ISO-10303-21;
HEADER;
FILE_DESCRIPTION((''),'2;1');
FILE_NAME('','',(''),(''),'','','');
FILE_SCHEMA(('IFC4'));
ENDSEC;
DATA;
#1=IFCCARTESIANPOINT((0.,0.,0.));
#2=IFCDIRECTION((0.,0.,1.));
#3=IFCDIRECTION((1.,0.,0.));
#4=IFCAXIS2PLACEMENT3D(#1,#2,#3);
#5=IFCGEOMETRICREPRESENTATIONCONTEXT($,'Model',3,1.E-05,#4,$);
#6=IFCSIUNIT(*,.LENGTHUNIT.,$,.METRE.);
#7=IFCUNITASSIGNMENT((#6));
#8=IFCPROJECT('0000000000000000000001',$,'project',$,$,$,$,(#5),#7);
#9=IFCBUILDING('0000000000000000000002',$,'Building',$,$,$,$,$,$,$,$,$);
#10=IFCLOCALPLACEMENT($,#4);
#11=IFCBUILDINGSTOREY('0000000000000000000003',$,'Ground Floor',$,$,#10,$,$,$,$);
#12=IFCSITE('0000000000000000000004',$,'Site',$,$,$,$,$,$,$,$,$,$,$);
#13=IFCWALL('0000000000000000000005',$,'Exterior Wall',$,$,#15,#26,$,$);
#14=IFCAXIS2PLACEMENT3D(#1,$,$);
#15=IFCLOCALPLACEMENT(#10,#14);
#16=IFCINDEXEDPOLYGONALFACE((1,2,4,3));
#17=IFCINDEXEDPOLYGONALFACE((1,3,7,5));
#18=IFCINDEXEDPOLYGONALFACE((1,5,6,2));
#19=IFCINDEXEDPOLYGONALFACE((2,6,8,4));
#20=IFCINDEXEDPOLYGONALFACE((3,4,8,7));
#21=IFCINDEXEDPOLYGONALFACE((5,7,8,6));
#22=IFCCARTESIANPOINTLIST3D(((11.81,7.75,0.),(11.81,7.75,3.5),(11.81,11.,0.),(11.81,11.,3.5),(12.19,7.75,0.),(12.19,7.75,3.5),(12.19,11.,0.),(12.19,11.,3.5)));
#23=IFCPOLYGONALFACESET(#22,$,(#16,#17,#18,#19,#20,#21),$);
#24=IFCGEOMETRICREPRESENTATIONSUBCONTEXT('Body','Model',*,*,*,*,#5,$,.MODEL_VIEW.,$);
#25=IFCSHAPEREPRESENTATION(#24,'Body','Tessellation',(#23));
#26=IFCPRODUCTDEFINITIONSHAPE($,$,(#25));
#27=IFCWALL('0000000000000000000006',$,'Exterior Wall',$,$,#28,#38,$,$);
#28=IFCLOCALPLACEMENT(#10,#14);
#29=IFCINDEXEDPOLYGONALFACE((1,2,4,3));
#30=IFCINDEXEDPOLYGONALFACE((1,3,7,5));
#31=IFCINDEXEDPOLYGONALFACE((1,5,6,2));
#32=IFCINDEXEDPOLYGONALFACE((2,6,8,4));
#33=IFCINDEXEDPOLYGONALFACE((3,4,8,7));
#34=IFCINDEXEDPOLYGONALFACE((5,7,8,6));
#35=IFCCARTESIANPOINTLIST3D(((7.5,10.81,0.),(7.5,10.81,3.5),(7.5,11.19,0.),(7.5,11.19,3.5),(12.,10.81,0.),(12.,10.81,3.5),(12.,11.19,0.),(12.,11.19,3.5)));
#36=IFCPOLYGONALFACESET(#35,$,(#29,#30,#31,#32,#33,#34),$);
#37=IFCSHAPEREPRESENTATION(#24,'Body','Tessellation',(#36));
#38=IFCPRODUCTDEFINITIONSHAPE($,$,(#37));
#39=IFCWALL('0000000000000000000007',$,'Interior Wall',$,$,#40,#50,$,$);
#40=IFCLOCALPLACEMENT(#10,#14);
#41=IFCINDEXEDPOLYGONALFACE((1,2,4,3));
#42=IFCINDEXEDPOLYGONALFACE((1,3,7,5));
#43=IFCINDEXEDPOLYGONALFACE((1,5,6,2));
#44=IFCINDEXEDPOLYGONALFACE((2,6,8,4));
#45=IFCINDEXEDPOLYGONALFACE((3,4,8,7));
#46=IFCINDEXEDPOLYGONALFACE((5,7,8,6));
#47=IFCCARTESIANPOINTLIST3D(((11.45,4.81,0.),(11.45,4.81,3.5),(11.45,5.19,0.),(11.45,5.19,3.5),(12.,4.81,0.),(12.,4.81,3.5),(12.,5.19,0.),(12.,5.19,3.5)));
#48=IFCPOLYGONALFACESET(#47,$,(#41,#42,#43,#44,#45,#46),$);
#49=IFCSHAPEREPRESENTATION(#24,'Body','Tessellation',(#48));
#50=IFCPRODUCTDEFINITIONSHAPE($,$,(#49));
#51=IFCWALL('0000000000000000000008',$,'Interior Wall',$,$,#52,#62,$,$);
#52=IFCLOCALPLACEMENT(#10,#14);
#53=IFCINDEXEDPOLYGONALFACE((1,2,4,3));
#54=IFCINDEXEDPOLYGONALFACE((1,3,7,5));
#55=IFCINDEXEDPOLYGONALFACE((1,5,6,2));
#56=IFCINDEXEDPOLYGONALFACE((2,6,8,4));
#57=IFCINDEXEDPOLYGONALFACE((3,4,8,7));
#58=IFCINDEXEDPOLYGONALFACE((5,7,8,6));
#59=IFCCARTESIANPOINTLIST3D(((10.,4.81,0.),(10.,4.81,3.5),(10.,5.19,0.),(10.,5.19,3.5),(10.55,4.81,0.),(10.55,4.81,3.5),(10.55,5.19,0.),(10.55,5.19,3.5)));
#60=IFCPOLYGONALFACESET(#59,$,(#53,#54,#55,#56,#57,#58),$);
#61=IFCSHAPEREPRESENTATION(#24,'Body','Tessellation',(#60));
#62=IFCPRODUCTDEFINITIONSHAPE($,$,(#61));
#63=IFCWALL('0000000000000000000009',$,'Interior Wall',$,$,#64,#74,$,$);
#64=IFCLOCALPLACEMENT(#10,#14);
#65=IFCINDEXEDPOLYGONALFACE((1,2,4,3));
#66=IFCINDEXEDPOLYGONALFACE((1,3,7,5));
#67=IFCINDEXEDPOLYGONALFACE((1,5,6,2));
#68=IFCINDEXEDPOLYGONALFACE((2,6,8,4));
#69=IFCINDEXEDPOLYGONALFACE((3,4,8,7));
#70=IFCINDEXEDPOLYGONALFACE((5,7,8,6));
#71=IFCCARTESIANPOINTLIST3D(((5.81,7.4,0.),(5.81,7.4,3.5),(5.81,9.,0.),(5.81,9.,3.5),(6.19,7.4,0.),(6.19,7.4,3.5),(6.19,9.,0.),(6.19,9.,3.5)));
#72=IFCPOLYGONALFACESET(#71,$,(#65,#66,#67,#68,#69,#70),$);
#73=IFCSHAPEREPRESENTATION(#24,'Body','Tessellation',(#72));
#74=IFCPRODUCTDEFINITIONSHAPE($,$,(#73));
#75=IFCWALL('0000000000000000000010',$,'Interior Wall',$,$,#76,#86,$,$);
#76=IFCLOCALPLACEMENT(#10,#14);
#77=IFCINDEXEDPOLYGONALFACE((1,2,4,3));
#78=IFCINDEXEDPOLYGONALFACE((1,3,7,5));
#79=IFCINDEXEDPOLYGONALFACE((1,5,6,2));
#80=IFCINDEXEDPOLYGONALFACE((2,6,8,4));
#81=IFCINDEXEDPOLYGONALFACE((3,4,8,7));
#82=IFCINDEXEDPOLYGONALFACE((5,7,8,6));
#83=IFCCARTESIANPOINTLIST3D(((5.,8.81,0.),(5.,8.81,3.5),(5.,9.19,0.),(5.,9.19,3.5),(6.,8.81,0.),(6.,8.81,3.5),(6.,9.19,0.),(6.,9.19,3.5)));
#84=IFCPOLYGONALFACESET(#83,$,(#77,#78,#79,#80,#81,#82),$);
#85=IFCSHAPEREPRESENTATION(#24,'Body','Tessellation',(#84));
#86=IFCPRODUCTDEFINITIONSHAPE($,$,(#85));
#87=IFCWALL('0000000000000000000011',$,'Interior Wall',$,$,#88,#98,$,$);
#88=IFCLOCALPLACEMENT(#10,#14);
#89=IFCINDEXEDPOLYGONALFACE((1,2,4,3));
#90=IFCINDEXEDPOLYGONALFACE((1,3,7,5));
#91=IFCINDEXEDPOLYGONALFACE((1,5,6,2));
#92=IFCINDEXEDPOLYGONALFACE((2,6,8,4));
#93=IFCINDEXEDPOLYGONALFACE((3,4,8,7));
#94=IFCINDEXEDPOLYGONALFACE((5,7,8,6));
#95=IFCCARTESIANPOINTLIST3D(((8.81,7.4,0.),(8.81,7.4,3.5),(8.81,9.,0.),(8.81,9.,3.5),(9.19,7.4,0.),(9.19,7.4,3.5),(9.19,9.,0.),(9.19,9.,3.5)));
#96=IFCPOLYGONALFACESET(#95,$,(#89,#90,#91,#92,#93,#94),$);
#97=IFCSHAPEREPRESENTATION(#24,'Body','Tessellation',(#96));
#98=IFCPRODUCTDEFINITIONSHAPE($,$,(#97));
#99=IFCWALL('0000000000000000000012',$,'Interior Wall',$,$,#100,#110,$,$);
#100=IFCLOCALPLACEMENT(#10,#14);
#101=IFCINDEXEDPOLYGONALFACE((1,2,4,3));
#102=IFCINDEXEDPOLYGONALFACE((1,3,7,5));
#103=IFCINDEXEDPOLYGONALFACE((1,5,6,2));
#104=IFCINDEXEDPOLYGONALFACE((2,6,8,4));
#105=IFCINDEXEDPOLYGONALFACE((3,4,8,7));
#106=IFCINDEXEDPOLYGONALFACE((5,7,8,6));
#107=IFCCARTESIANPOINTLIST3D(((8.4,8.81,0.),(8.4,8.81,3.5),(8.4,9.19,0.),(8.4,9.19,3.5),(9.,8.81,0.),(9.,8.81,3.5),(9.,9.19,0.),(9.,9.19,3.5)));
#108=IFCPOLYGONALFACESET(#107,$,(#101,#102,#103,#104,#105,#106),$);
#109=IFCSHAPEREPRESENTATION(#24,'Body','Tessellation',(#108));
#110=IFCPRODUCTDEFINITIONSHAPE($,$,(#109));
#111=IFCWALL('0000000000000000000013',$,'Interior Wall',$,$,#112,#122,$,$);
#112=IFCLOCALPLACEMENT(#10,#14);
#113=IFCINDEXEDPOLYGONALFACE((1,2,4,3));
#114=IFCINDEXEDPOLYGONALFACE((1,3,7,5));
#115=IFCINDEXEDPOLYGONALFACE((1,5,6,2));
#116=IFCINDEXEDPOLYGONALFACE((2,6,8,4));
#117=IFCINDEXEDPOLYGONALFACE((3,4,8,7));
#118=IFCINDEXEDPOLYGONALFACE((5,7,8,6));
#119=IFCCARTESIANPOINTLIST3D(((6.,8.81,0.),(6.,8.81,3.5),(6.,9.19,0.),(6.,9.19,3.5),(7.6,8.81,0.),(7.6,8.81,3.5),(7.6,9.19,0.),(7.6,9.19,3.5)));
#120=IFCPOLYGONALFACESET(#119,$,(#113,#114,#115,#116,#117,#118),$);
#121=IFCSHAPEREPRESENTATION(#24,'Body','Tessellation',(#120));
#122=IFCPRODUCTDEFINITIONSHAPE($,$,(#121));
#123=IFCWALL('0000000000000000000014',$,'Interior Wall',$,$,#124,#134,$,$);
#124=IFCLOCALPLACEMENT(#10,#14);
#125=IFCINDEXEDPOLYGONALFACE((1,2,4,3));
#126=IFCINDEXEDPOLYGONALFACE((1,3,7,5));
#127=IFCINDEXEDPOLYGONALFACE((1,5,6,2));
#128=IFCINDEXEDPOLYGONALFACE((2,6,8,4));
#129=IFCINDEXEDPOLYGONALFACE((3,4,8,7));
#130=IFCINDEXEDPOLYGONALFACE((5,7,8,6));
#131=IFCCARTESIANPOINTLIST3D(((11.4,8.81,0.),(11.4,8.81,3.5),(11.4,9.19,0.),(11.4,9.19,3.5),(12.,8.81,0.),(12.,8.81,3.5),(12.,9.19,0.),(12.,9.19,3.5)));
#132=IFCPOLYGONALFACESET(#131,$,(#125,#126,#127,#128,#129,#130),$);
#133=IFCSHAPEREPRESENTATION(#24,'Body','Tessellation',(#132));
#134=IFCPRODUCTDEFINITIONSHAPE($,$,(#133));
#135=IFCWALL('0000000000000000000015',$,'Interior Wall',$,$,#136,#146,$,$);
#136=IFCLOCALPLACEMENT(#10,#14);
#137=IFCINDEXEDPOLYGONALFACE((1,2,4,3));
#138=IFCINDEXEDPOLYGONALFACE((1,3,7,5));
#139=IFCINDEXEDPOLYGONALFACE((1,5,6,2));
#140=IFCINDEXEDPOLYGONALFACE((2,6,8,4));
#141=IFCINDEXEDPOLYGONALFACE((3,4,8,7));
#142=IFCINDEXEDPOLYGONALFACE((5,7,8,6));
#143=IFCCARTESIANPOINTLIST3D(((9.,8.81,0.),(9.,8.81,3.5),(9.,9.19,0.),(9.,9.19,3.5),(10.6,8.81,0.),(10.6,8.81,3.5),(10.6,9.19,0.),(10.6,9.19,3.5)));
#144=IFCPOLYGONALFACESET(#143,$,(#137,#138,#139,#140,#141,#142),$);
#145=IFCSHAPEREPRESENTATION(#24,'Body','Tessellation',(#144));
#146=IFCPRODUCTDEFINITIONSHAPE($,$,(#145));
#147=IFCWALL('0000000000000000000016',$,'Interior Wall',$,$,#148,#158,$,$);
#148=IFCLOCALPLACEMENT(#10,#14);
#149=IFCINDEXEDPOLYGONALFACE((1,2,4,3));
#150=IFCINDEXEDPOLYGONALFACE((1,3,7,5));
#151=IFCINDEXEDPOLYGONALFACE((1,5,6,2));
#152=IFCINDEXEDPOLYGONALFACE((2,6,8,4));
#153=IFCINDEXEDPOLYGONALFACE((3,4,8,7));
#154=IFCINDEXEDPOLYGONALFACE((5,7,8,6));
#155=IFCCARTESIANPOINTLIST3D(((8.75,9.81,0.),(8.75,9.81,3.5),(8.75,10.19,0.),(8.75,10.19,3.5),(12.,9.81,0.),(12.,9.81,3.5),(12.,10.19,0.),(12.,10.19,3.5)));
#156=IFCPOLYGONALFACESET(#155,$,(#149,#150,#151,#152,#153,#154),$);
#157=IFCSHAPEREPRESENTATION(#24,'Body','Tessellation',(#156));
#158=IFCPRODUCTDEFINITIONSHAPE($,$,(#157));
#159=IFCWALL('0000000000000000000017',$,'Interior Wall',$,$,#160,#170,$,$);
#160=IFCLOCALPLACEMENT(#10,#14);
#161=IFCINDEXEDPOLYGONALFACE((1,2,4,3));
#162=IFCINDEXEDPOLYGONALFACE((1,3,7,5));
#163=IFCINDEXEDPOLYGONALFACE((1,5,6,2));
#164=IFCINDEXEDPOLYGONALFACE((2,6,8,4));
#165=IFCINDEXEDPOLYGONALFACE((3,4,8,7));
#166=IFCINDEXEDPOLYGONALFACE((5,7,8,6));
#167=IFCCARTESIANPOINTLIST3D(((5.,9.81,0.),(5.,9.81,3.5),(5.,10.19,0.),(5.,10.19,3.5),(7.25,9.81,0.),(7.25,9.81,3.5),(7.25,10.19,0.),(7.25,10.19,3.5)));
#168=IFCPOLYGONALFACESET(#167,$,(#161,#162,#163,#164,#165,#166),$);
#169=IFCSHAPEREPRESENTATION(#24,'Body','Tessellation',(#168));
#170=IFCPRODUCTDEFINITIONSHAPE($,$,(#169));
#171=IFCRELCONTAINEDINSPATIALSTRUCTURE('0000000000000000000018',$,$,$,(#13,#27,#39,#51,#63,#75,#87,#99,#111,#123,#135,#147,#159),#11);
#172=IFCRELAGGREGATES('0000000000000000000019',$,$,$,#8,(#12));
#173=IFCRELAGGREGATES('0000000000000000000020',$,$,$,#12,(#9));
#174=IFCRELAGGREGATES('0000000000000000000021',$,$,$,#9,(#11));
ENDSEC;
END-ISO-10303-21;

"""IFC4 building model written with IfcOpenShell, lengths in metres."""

from ifc_helpers import new_model, si_unit, frame, origin_with_axes, place, context, subcontext, project, spatial, indexed_curve, outline, extrude, element, save


model = new_model("IFC4")

# Units and contexts
model_context = context("Model", 3, precision=1e-05, world=origin_with_axes())
body_context = subcontext(model_context, "Body", "Model", "MODEL_VIEW")
ifc_project = project(units=[si_unit("LENGTHUNIT", "METRE")], contexts=[model_context])

# Site, building, storey
site = spatial("IfcSite", under=ifc_project, Name="Site")
building = spatial("IfcBuilding", under=site, Name="Building")
storey_placement = place(None, origin_with_axes())
storey = spatial("IfcBuildingStorey", under=building, at=storey_placement, Name="Ground Floor")

# Walls
wall_1_placement = place(storey_placement, frame((12.0, 7.75, 0.0), z_axis=(0.0, 0.0, 1.0), x_axis=(0.0, 1.0, 0.0)))
element("IfcWall", 1, at=wall_1_placement, inside=storey, Name="Exterior Wall", context=body_context, shape_type="SweptSolid", body=[
    extrude(outline(indexed_curve([(0.0, 0.0), (0.0, 0.38), (3.25, 0.38), (3.25, 0.0), (0.0, 0.0)], self_intersect=False)), frame((0.0, -0.19, 0.0), z_axis=(0.0, 0.0, 1.0), x_axis=(1.0, 0.0, 0.0)), (0.0, 0.0, 1.0), 3.5),
])
wall_2_placement = place(storey_placement, frame((12.0, 11.0, 0.0), z_axis=(0.0, 0.0, 1.0), x_axis=(-1.0, 0.0, 0.0)))
element("IfcWall", 2, at=wall_2_placement, inside=storey, Name="Exterior Wall", context=body_context, shape_type="SweptSolid", body=[
    extrude(outline(indexed_curve([(0.0, 0.0), (0.0, 0.38), (4.5, 0.38), (4.5, 0.0), (0.0, 0.0)], self_intersect=False)), frame((0.0, -0.19, 0.0), z_axis=(0.0, 0.0, 1.0), x_axis=(1.0, 0.0, 0.0)), (0.0, 0.0, 1.0), 3.5),
])
for number, where, z_axis, x_axis, name in (
    (3, (12.0, 5.0, 0.0), (0.0, 0.0, 1.0), (-1.0, 0.0, 0.0), "Interior Wall"),
    (4, (10.55, 5.0, 0.0), (0.0, 0.0, 1.0), (-1.0, 0.0, 0.0), "Interior Wall"),
):
    element("IfcWall", number, at=place(storey_placement, frame(where, z_axis=z_axis, x_axis=x_axis)), inside=storey, Name=name, context=body_context, shape_type="SweptSolid", body=[
        extrude(outline(indexed_curve([(0.0, 0.0), (0.0, 0.38), (0.55, 0.38), (0.55, 0.0), (0.0, 0.0)], self_intersect=False)), frame((0.0, -0.19, 0.0), z_axis=(0.0, 0.0, 1.0), x_axis=(1.0, 0.0, 0.0)), (0.0, 0.0, 1.0), 3.5),
    ])
wall_3_placement = place(storey_placement, frame((6.0, 7.4, 0.0), z_axis=(0.0, 0.0, 1.0), x_axis=(0.0, 1.0, 0.0)))
element("IfcWall", 5, at=wall_3_placement, inside=storey, Name="Interior Wall", context=body_context, shape_type="SweptSolid", body=[
    extrude(outline(indexed_curve([(0.0, 0.0), (0.0, 0.38), (1.6, 0.38), (1.6, 0.0), (0.0, 0.0)], self_intersect=False)), frame((0.0, -0.19, 0.0), z_axis=(0.0, 0.0, 1.0), x_axis=(1.0, 0.0, 0.0)), (0.0, 0.0, 1.0), 3.5),
])
wall_4_placement = place(storey_placement, frame((6.0, 9.0, 0.0), z_axis=(0.0, 0.0, 1.0), x_axis=(-1.0, 0.0, 0.0)))
element("IfcWall", 6, at=wall_4_placement, inside=storey, Name="Interior Wall", context=body_context, shape_type="SweptSolid", body=[
    extrude(outline(indexed_curve([(0.0, 0.0), (0.0, 0.38), (1.0, 0.38), (1.0, 0.0), (0.0, 0.0)], self_intersect=False)), frame((0.0, -0.19, 0.0), z_axis=(0.0, 0.0, 1.0), x_axis=(1.0, 0.0, 0.0)), (0.0, 0.0, 1.0), 3.5),
])
wall_5_placement = place(storey_placement, frame((9.0, 7.4, 0.0), z_axis=(0.0, 0.0, 1.0), x_axis=(0.0, 1.0, 0.0)))
element("IfcWall", 7, at=wall_5_placement, inside=storey, Name="Interior Wall", context=body_context, shape_type="SweptSolid", body=[
    extrude(outline(indexed_curve([(0.0, 0.0), (0.0, 0.38), (1.6, 0.38), (1.6, 0.0), (0.0, 0.0)], self_intersect=False)), frame((0.0, -0.19, 0.0), z_axis=(0.0, 0.0, 1.0), x_axis=(1.0, 0.0, 0.0)), (0.0, 0.0, 1.0), 3.5),
])
wall_6_placement = place(storey_placement, frame((9.0, 9.0, 0.0), z_axis=(0.0, 0.0, 1.0), x_axis=(-1.0, 0.0, 0.0)))
element("IfcWall", 8, at=wall_6_placement, inside=storey, Name="Interior Wall", context=body_context, shape_type="SweptSolid", body=[
    extrude(outline(indexed_curve([(0.0, 0.0), (0.0, 0.38), (0.6, 0.38), (0.6, 0.0), (0.0, 0.0)], self_intersect=False)), frame((0.0, -0.19, 0.0), z_axis=(0.0, 0.0, 1.0), x_axis=(1.0, 0.0, 0.0)), (0.0, 0.0, 1.0), 3.5),
])
wall_7_placement = place(storey_placement, frame((7.6, 9.0, 0.0), z_axis=(0.0, 0.0, 1.0), x_axis=(-1.0, 0.0, 0.0)))
element("IfcWall", 9, at=wall_7_placement, inside=storey, Name="Interior Wall", context=body_context, shape_type="SweptSolid", body=[
    extrude(outline(indexed_curve([(0.0, 0.0), (0.0, 0.38), (1.6, 0.38), (1.6, 0.0), (0.0, 0.0)], self_intersect=False)), frame((0.0, -0.19, 0.0), z_axis=(0.0, 0.0, 1.0), x_axis=(1.0, 0.0, 0.0)), (0.0, 0.0, 1.0), 3.5),
])
wall_8_placement = place(storey_placement, frame((12.0, 9.0, 0.0), z_axis=(0.0, 0.0, 1.0), x_axis=(-1.0, 0.0, 0.0)))
element("IfcWall", 10, at=wall_8_placement, inside=storey, Name="Interior Wall", context=body_context, shape_type="SweptSolid", body=[
    extrude(outline(indexed_curve([(0.0, 0.0), (0.0, 0.38), (0.6, 0.38), (0.6, 0.0), (0.0, 0.0)], self_intersect=False)), frame((0.0, -0.19, 0.0), z_axis=(0.0, 0.0, 1.0), x_axis=(1.0, 0.0, 0.0)), (0.0, 0.0, 1.0), 3.5),
])
wall_9_placement = place(storey_placement, frame((10.6, 9.0, 0.0), z_axis=(0.0, 0.0, 1.0), x_axis=(-1.0, 0.0, 0.0)))
element("IfcWall", 11, at=wall_9_placement, inside=storey, Name="Interior Wall", context=body_context, shape_type="SweptSolid", body=[
    extrude(outline(indexed_curve([(0.0, 0.0), (0.0, 0.38), (1.6, 0.38), (1.6, 0.0), (0.0, 0.0)], self_intersect=False)), frame((0.0, -0.19, 0.0), z_axis=(0.0, 0.0, 1.0), x_axis=(1.0, 0.0, 0.0)), (0.0, 0.0, 1.0), 3.5),
])
wall_10_placement = place(storey_placement, frame((12.0, 10.0, 0.0), z_axis=(0.0, 0.0, 1.0), x_axis=(-1.0, 0.0, 0.0)))
element("IfcWall", 12, at=wall_10_placement, inside=storey, Name="Interior Wall", context=body_context, shape_type="SweptSolid", body=[
    extrude(outline(indexed_curve([(0.0, 0.0), (0.0, 0.38), (3.25, 0.38), (3.25, 0.0), (0.0, 0.0)], self_intersect=False)), frame((0.0, -0.19, 0.0), z_axis=(0.0, 0.0, 1.0), x_axis=(1.0, 0.0, 0.0)), (0.0, 0.0, 1.0), 3.5),
])
wall_11_placement = place(storey_placement, frame((7.25, 10.0, 0.0), z_axis=(0.0, 0.0, 1.0), x_axis=(-1.0, 0.0, 0.0)))
element("IfcWall", 13, at=wall_11_placement, inside=storey, Name="Interior Wall", context=body_context, shape_type="SweptSolid", body=[
    extrude(outline(indexed_curve([(0.0, 0.0), (0.0, 0.38), (2.25, 0.38), (2.25, 0.0), (0.0, 0.0)], self_intersect=False)), frame((0.0, -0.19, 0.0), z_axis=(0.0, 0.0, 1.0), x_axis=(1.0, 0.0, 0.0)), (0.0, 0.0, 1.0), 3.5),
])

save(model, "model.ifc")
